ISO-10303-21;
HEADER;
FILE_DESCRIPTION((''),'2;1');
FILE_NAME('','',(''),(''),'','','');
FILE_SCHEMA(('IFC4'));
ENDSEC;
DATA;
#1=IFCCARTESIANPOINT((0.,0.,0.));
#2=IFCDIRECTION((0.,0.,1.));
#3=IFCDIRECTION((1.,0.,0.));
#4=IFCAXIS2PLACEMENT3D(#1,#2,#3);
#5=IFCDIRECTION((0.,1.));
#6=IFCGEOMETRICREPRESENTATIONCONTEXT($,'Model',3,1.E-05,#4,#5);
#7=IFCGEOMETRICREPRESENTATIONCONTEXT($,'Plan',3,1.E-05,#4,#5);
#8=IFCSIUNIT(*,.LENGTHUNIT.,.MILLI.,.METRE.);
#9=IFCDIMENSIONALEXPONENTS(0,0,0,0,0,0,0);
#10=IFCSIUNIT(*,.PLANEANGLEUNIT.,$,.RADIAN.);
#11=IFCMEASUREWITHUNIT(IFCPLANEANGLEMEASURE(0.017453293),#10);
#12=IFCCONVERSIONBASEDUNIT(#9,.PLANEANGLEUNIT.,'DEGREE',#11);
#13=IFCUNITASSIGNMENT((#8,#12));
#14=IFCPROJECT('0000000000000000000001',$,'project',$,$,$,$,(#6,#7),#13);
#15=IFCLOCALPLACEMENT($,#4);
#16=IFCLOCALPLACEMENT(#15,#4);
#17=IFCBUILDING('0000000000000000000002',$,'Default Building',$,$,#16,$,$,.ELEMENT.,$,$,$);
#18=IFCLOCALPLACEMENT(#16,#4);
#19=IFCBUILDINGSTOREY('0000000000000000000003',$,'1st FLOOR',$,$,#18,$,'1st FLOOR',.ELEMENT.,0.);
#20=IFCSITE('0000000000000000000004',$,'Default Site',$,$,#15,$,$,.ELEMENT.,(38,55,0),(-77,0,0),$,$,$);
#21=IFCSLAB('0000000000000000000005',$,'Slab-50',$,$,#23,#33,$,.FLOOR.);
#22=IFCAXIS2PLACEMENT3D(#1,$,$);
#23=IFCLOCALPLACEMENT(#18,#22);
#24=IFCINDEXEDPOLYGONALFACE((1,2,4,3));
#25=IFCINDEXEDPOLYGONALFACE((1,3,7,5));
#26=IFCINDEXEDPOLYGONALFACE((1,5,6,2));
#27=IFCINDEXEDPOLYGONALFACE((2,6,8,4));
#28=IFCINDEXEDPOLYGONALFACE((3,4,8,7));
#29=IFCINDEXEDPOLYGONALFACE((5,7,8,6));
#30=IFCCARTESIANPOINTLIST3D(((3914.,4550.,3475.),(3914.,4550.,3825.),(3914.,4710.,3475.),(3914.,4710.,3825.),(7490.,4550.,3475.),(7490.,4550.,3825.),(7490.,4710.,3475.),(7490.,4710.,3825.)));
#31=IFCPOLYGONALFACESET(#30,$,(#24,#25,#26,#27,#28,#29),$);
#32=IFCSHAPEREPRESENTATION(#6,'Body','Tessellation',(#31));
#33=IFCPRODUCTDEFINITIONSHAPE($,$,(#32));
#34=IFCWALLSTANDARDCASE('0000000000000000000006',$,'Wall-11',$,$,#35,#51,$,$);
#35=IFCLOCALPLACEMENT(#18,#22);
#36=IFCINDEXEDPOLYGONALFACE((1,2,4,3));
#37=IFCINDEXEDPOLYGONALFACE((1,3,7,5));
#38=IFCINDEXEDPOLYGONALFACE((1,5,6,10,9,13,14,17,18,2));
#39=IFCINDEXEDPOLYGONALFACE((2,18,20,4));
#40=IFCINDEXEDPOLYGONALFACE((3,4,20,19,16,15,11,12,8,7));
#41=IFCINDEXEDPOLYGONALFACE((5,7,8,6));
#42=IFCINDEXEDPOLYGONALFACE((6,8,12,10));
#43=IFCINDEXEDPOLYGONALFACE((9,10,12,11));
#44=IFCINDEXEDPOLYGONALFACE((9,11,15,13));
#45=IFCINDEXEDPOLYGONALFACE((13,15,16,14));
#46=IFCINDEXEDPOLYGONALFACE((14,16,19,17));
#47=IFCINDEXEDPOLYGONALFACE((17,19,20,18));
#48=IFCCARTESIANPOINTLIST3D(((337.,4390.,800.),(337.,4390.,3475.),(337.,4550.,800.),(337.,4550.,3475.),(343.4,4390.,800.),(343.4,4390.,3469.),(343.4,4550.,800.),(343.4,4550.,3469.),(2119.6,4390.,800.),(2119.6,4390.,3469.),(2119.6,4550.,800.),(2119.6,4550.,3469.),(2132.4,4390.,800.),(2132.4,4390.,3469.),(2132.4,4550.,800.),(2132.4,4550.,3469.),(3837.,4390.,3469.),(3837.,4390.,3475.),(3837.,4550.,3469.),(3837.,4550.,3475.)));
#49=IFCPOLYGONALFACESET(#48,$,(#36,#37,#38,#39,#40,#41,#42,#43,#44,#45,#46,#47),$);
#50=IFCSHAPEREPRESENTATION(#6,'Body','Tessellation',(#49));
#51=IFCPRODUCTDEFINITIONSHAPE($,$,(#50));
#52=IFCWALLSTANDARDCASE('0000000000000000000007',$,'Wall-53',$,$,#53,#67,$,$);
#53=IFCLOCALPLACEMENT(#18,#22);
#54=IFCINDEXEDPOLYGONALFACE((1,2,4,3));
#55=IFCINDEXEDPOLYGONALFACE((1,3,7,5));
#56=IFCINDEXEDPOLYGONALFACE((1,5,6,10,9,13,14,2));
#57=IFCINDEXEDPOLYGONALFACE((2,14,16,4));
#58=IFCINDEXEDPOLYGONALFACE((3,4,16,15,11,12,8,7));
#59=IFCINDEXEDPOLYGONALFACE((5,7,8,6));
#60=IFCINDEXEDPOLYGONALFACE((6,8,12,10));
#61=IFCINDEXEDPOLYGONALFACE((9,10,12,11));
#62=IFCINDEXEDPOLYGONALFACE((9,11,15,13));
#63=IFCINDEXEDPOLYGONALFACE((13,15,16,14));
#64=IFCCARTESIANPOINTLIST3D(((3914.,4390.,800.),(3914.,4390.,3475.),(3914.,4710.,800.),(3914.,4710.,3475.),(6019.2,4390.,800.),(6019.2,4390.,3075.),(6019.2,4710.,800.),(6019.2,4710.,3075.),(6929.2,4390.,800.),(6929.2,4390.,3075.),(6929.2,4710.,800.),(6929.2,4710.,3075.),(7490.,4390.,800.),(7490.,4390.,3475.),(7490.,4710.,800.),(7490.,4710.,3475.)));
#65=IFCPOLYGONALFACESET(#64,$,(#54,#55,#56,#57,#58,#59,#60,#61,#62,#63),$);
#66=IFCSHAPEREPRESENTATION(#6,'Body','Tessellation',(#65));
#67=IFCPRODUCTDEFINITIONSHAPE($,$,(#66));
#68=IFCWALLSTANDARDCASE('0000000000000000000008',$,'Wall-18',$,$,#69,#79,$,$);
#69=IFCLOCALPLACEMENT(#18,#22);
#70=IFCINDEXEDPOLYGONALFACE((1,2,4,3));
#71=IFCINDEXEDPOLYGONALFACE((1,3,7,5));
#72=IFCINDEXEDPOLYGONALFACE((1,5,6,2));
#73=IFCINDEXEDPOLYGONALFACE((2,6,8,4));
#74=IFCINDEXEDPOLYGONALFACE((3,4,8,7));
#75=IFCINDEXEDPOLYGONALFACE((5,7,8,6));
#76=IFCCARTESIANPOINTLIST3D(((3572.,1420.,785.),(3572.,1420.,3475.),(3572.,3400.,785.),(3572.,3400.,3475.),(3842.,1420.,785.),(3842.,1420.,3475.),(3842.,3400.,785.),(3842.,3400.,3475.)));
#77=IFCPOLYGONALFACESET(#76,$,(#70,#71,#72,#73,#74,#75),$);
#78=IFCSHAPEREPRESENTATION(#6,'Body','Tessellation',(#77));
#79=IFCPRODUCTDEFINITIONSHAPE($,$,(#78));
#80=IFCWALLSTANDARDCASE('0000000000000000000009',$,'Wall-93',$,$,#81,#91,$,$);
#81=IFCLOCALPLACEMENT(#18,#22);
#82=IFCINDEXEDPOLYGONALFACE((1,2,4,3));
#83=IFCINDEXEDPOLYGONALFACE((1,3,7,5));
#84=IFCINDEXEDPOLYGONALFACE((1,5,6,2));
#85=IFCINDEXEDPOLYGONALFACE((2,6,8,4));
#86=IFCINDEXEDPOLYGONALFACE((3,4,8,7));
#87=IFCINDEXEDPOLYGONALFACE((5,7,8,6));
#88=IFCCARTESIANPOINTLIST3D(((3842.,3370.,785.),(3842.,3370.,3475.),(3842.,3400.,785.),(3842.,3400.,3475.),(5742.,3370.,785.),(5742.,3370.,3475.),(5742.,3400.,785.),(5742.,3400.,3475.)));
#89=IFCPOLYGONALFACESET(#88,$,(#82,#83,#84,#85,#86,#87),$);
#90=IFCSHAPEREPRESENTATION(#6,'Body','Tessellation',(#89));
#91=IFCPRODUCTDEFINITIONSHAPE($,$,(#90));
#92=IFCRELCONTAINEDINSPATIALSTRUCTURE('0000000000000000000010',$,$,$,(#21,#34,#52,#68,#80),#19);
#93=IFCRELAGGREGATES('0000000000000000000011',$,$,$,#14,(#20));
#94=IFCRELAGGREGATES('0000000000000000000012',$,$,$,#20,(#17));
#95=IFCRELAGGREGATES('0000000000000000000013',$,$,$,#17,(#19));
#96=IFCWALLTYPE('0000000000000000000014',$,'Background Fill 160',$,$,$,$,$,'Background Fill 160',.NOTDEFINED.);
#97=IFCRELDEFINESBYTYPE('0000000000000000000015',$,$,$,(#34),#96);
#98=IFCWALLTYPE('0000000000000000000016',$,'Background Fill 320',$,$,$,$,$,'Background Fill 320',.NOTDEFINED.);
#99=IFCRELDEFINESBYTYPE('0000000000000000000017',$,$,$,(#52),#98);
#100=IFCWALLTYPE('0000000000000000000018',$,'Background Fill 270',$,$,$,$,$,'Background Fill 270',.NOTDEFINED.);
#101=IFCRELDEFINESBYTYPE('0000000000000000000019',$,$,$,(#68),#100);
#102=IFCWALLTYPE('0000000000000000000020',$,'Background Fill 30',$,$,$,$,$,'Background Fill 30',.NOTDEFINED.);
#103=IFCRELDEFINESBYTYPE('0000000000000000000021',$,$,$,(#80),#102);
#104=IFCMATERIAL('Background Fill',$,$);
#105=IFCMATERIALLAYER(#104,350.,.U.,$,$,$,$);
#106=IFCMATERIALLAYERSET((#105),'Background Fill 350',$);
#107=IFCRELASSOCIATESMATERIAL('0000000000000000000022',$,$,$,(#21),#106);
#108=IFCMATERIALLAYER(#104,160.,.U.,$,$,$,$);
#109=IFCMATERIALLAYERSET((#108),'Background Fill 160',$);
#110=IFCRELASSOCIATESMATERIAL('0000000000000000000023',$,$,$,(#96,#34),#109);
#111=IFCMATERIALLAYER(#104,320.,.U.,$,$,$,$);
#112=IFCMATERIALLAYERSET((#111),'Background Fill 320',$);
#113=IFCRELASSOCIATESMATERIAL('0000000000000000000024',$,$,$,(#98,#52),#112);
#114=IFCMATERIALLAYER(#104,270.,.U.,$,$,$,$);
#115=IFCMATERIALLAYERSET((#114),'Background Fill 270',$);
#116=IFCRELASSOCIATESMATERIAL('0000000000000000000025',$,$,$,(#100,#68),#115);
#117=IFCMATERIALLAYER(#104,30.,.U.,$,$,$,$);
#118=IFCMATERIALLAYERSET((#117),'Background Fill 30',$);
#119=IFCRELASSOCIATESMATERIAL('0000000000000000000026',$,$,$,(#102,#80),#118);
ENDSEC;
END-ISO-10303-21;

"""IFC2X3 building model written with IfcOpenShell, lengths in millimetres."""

from ifc_helpers import new_model, entity, si_unit, converted_unit, direction, frame, origin_with_axes, place, context, project, spatial, polyline, outline, extrude, material, layer, layer_set, layer_usage, type_object, element, save


model = new_model("IFC2X3")

# Units and contexts
model_context = context("Model", 3, precision=1e-05, world=origin_with_axes(), true_north=direction((0.0, 1.0)))
plan_context = context("Plan", 3, precision=1e-05, world=origin_with_axes(), true_north=direction((0.0, 1.0)))
ifc_project = project(units=[si_unit("LENGTHUNIT", "METRE", prefix="MILLI"), converted_unit("PLANEANGLEUNIT", "DEGREE", entity("IfcPlaneAngleMeasure", 0.017453293), si_unit("PLANEANGLEUNIT", "RADIAN"), dimensions=[0, 0, 0, 0, 0, 0, 0])], contexts=[model_context, plan_context])

# Site, building, storey
site_placement = place(None, origin_with_axes())
site = spatial("IfcSite", under=ifc_project, at=site_placement, Name="Default Site", CompositionType="ELEMENT", RefLatitude=(38, 55, 0), RefLongitude=(-77, 0, 0))
building_placement = place(site_placement, origin_with_axes())
building = spatial("IfcBuilding", under=site, at=building_placement, Name="Default Building", CompositionType="ELEMENT")
storey_placement = place(building_placement, origin_with_axes())
storey = spatial("IfcBuildingStorey", under=building, at=storey_placement, Name="1st FLOOR", LongName="1st FLOOR", CompositionType="ELEMENT", Elevation=0.0)

# Slab
ifc_material = material(Name="Background Fill")
ifc_layer_1 = layer(ifc_material, 350.0, ventilated="UNKNOWN")
ifc_layer_set_1 = layer_set([ifc_layer_1], Name="Background Fill 350")
ifc_layer_usage_1 = layer_usage(ifc_layer_set_1, "AXIS3", "NEGATIVE", 350.0)
slab_1_placement = place(storey_placement, frame((3914.0, 4550.0, 3475.0), z_axis=(0.0, 0.0, 1.0), x_axis=(1.0, 0.0, 0.0)))
element("IfcSlab", 1, at=slab_1_placement, inside=storey, material=ifc_layer_usage_1, Name="Slab-50", PredefinedType="FLOOR", context=model_context, shape_type="SweptSolid", body=[
    extrude(outline(polyline([(0.0, 0.0), (3576.0, 0.0), (3576.0, 160.0), (0.0, 160.0), (0.0, 0.0)])), origin_with_axes(), (0.0, 0.0, 1.0), 350.0),
])

# Wall, openings
ifc_layer_2 = layer(ifc_material, 160.0, ventilated="UNKNOWN")
ifc_layer_set_2 = layer_set([ifc_layer_2], Name="Background Fill 160")
ifc_layer_usage_2 = layer_usage(ifc_layer_set_2, "AXIS2", "NEGATIVE", 0.0)
wall_type_1 = type_object("IfcWallType", Name="Background Fill 160", ElementType="Background Fill 160", PredefinedType="NOTDEFINED", material=ifc_layer_set_2)
wall_1_placement = place(storey_placement, frame((337.0, 4550.0, 800.0), z_axis=(0.0, 0.0, 1.0), x_axis=(1.0, 0.0, 0.0)))
wall_1 = element("IfcWallStandardCase", 2, at=wall_1_placement, inside=storey, type_object=wall_type_1, material=ifc_layer_usage_2, Name="Wall-11", context=model_context, shape_type="SweptSolid", body=[
    extrude(outline(polyline([(0.0, -160.0), (3500.0, -160.0), (3500.0, 0.0), (0.0, 0.0), (0.0, -160.0)])), origin_with_axes(), (0.0, 0.0, 1.0), 2675.0),
])
opening_1_placement = place(wall_1_placement, frame((894.5, -160.0, 0.0), z_axis=(0.0, 0.0, 1.0), x_axis=(1.0, 0.0, 0.0)))
element("IfcOpeningElement", 3, at=opening_1_placement, cuts=wall_1, ObjectType="Opening", context=model_context, shape_type="SweptSolid", body=[
    extrude(outline(polyline([(-888.1, 0.0), (888.1, 0.0), (888.1, 2669.0), (-888.1, 2669.0), (-888.1, 0.0)])), frame((0.0, 0.0, 0.0), z_axis=(0.0, 1.0, 0.0), x_axis=(-1.0, 0.0, 0.0)), (0.0, 0.0, 1.0), 160.0),
])
opening_2_placement = place(wall_1_placement, frame((2683.0, -160.0, 0.0), z_axis=(0.0, 0.0, 1.0), x_axis=(1.0, 0.0, 0.0)))
element("IfcOpeningElement", 4, at=opening_2_placement, cuts=wall_1, ObjectType="Opening", context=model_context, shape_type="SweptSolid", body=[
    extrude(outline(polyline([(-887.6, 0.0), (887.6, 0.0), (887.6, 2669.0), (-887.6, 2669.0), (-887.6, 0.0)])), frame((0.0, 0.0, 0.0), z_axis=(0.0, 1.0, 0.0), x_axis=(-1.0, 0.0, 0.0)), (0.0, 0.0, 1.0), 160.0),
])

# Wall, opening
ifc_layer_3 = layer(ifc_material, 320.0, ventilated="UNKNOWN")
ifc_layer_set_3 = layer_set([ifc_layer_3], Name="Background Fill 320")
ifc_layer_usage_3 = layer_usage(ifc_layer_set_3, "AXIS2", "NEGATIVE", 0.0)
wall_type_2 = type_object("IfcWallType", Name="Background Fill 320", ElementType="Background Fill 320", PredefinedType="NOTDEFINED", material=ifc_layer_set_3)
wall_2_placement = place(storey_placement, frame((3914.0, 4710.0, 800.0), z_axis=(0.0, 0.0, 1.0), x_axis=(1.0, 0.0, 0.0)))
wall_2 = element("IfcWallStandardCase", 5, at=wall_2_placement, inside=storey, type_object=wall_type_2, material=ifc_layer_usage_3, Name="Wall-53", context=model_context, shape_type="SweptSolid", body=[
    extrude(outline(polyline([(0.0, -320.0), (3576.0, -320.0), (3576.0, 0.0), (0.0, 0.0), (0.0, -320.0)])), origin_with_axes(), (0.0, 0.0, 1.0), 2675.0),
])
opening_3_placement = place(wall_2_placement, frame((2560.2, -320.0, 0.0), z_axis=(0.0, 0.0, 1.0), x_axis=(1.0, 0.0, 0.0)))
element("IfcOpeningElement", 6, at=opening_3_placement, cuts=wall_2, ObjectType="Opening", context=model_context, shape_type="SweptSolid", body=[
    extrude(outline(polyline([(-455.0, 0.0), (455.0, 0.0), (455.0, 2275.0), (-455.0, 2275.0), (-455.0, 0.0)])), frame((0.0, 0.0, 0.0), z_axis=(0.0, 1.0, 0.0), x_axis=(-1.0, 0.0, 0.0)), (0.0, 0.0, 1.0), 320.0),
])

# Walls
ifc_layer_4 = layer(ifc_material, 270.0, ventilated="UNKNOWN")
ifc_layer_set_4 = layer_set([ifc_layer_4], Name="Background Fill 270")
ifc_layer_usage_4 = layer_usage(ifc_layer_set_4, "AXIS2", "NEGATIVE", 0.0)
wall_type_3 = type_object("IfcWallType", Name="Background Fill 270", ElementType="Background Fill 270", PredefinedType="NOTDEFINED", material=ifc_layer_set_4)
wall_3_placement = place(storey_placement, frame((3572.0, 1420.0, 785.0), z_axis=(0.0, 0.0, 1.0), x_axis=(0.0, 1.0, 0.0)))
element("IfcWallStandardCase", 7, at=wall_3_placement, inside=storey, type_object=wall_type_3, material=ifc_layer_usage_4, Name="Wall-18", context=model_context, shape_type="SweptSolid", body=[
    extrude(outline(polyline([(0.0, -270.0), (1980.0, -270.0), (1980.0, 0.0), (0.0, 0.0), (0.0, -270.0)])), origin_with_axes(), (0.0, 0.0, 1.0), 2690.0),
])
ifc_layer_5 = layer(ifc_material, 30.0, ventilated="UNKNOWN")
ifc_layer_set_5 = layer_set([ifc_layer_5], Name="Background Fill 30")
ifc_layer_usage_5 = layer_usage(ifc_layer_set_5, "AXIS2", "NEGATIVE", 0.0)
wall_type_4 = type_object("IfcWallType", Name="Background Fill 30", ElementType="Background Fill 30", PredefinedType="NOTDEFINED", material=ifc_layer_set_5)
wall_4_placement = place(storey_placement, frame((3842.0, 3400.0, 785.0), z_axis=(0.0, 0.0, 1.0), x_axis=(1.0, 0.0, 0.0)))
element("IfcWallStandardCase", 8, at=wall_4_placement, inside=storey, type_object=wall_type_4, material=ifc_layer_usage_5, Name="Wall-93", context=model_context, shape_type="SweptSolid", body=[
    extrude(outline(polyline([(0.0, -30.0), (1900.0, -30.0), (1900.0, 0.0), (0.0, 0.0), (0.0, -30.0)])), origin_with_axes(), (0.0, 0.0, 1.0), 2690.0),
])

save(model, "model.ifc")
